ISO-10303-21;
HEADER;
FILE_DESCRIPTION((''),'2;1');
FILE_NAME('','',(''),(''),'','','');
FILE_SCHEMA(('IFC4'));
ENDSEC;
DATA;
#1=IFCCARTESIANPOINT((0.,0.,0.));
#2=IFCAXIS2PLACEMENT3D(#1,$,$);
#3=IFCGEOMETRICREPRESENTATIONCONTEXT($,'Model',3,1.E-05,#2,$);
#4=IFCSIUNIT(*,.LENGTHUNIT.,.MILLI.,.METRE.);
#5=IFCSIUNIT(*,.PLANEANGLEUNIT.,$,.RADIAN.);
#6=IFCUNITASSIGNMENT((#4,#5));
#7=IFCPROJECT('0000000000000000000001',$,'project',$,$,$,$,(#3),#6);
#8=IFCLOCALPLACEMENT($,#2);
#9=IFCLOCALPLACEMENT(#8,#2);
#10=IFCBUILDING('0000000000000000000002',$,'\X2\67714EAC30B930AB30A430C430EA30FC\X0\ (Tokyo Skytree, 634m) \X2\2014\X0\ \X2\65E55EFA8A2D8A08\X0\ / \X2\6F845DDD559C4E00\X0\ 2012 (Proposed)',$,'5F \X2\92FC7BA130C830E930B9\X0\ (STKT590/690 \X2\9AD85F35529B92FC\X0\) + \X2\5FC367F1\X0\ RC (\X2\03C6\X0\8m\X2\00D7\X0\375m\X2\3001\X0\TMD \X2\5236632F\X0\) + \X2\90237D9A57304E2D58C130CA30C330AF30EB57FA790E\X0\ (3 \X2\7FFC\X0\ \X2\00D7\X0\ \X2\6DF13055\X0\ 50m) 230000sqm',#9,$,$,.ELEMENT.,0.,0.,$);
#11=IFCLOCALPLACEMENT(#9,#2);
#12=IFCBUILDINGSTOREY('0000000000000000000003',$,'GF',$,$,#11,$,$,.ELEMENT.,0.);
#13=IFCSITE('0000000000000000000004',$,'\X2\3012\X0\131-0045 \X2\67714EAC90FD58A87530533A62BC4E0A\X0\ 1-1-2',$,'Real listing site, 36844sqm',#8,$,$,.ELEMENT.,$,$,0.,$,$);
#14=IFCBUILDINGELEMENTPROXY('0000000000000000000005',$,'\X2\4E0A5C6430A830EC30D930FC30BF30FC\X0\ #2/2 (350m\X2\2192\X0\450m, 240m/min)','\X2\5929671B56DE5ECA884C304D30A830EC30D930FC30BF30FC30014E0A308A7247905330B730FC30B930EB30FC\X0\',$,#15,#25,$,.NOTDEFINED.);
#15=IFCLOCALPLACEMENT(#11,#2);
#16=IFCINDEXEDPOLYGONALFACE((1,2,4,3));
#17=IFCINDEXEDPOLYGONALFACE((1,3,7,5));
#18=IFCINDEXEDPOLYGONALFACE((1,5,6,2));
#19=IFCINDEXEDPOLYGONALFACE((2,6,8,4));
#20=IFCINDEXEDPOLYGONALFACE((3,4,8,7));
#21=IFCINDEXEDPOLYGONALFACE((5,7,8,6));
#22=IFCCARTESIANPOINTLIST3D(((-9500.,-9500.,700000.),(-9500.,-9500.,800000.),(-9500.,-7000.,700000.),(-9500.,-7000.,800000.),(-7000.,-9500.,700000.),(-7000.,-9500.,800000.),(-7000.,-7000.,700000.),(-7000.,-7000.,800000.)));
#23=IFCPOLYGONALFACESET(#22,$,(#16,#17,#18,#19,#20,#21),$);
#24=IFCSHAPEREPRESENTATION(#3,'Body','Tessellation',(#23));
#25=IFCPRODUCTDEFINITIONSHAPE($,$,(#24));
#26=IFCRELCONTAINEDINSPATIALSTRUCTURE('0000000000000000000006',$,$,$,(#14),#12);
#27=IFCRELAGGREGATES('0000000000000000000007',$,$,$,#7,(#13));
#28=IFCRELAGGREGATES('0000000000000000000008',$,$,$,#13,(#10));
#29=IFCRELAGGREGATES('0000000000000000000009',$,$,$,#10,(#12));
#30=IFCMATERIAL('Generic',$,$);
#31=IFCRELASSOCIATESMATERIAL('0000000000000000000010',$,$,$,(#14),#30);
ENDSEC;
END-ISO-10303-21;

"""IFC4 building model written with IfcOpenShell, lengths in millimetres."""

from ifc_helpers import new_model, si_unit, frame, frame_2d, origin, place, context, project, spatial, rectangle, extrude, material, element, save


model = new_model("IFC4")

# Units and contexts
model_context = context("Model", 3, precision=1e-05, world=origin())
ifc_project = project(units=[si_unit("LENGTHUNIT", "METRE", prefix="MILLI"), si_unit("PLANEANGLEUNIT", "RADIAN")], contexts=[model_context])

# Site, building, storey
site_placement = place(None, origin())
site = spatial("IfcSite", under=ifc_project, at=site_placement, Name="〒131-0045 東京都墨田区押上 1-1-2", ObjectType="Real listing site, 36844sqm", CompositionType="ELEMENT", RefElevation=0.0)
building_placement = place(site_placement, origin())
building = spatial("IfcBuilding", under=site, at=building_placement, Name="東京スカイツリー (Tokyo Skytree, 634m) — 日建設計 / 澄川喜一 2012 (Proposed)", ObjectType="5F 鋼管トラス (STKT590/690 高張力鋼) + 心柱 RC (φ8m×375m、TMD 制振) + 連続地中壁ナックル基礎 (3 翼 × 深さ 50m) 230000sqm", CompositionType="ELEMENT", ElevationOfRefHeight=0.0, ElevationOfTerrain=0.0)
storey_placement = place(building_placement, origin())
storey = spatial("IfcBuildingStorey", under=building, at=storey_placement, Name="GF", CompositionType="ELEMENT", Elevation=0.0)

# Shared definitions
ifc_material_1 = material(Name="Generic")

# Building element proxy
proxy_1_placement = place(storey_placement, frame((0.0, -7000.0, 350000.0), x_axis=(0.0, -1.0, 0.0)))
element("IfcBuildingElementProxy", 1, at=proxy_1_placement, inside=storey, material=ifc_material_1, Name="上層エレベーター #2/2 (350m→450m, 240m/min)", Description="天望回廊行きエレベーター、上り片道シースルー", PredefinedType="NOTDEFINED", context=model_context, shape_type="SweptSolid", body=[
    extrude(rectangle(XDim=2500.0, YDim=2500.0, at=frame_2d((1250.0, 1250.0))), frame((0.0, -7000.0, 350000.0), x_axis=(0.0, -1.0, 0.0)), (0.0, 0.0, 1.0), 100000.0),
])

save(model, "model.ifc")
